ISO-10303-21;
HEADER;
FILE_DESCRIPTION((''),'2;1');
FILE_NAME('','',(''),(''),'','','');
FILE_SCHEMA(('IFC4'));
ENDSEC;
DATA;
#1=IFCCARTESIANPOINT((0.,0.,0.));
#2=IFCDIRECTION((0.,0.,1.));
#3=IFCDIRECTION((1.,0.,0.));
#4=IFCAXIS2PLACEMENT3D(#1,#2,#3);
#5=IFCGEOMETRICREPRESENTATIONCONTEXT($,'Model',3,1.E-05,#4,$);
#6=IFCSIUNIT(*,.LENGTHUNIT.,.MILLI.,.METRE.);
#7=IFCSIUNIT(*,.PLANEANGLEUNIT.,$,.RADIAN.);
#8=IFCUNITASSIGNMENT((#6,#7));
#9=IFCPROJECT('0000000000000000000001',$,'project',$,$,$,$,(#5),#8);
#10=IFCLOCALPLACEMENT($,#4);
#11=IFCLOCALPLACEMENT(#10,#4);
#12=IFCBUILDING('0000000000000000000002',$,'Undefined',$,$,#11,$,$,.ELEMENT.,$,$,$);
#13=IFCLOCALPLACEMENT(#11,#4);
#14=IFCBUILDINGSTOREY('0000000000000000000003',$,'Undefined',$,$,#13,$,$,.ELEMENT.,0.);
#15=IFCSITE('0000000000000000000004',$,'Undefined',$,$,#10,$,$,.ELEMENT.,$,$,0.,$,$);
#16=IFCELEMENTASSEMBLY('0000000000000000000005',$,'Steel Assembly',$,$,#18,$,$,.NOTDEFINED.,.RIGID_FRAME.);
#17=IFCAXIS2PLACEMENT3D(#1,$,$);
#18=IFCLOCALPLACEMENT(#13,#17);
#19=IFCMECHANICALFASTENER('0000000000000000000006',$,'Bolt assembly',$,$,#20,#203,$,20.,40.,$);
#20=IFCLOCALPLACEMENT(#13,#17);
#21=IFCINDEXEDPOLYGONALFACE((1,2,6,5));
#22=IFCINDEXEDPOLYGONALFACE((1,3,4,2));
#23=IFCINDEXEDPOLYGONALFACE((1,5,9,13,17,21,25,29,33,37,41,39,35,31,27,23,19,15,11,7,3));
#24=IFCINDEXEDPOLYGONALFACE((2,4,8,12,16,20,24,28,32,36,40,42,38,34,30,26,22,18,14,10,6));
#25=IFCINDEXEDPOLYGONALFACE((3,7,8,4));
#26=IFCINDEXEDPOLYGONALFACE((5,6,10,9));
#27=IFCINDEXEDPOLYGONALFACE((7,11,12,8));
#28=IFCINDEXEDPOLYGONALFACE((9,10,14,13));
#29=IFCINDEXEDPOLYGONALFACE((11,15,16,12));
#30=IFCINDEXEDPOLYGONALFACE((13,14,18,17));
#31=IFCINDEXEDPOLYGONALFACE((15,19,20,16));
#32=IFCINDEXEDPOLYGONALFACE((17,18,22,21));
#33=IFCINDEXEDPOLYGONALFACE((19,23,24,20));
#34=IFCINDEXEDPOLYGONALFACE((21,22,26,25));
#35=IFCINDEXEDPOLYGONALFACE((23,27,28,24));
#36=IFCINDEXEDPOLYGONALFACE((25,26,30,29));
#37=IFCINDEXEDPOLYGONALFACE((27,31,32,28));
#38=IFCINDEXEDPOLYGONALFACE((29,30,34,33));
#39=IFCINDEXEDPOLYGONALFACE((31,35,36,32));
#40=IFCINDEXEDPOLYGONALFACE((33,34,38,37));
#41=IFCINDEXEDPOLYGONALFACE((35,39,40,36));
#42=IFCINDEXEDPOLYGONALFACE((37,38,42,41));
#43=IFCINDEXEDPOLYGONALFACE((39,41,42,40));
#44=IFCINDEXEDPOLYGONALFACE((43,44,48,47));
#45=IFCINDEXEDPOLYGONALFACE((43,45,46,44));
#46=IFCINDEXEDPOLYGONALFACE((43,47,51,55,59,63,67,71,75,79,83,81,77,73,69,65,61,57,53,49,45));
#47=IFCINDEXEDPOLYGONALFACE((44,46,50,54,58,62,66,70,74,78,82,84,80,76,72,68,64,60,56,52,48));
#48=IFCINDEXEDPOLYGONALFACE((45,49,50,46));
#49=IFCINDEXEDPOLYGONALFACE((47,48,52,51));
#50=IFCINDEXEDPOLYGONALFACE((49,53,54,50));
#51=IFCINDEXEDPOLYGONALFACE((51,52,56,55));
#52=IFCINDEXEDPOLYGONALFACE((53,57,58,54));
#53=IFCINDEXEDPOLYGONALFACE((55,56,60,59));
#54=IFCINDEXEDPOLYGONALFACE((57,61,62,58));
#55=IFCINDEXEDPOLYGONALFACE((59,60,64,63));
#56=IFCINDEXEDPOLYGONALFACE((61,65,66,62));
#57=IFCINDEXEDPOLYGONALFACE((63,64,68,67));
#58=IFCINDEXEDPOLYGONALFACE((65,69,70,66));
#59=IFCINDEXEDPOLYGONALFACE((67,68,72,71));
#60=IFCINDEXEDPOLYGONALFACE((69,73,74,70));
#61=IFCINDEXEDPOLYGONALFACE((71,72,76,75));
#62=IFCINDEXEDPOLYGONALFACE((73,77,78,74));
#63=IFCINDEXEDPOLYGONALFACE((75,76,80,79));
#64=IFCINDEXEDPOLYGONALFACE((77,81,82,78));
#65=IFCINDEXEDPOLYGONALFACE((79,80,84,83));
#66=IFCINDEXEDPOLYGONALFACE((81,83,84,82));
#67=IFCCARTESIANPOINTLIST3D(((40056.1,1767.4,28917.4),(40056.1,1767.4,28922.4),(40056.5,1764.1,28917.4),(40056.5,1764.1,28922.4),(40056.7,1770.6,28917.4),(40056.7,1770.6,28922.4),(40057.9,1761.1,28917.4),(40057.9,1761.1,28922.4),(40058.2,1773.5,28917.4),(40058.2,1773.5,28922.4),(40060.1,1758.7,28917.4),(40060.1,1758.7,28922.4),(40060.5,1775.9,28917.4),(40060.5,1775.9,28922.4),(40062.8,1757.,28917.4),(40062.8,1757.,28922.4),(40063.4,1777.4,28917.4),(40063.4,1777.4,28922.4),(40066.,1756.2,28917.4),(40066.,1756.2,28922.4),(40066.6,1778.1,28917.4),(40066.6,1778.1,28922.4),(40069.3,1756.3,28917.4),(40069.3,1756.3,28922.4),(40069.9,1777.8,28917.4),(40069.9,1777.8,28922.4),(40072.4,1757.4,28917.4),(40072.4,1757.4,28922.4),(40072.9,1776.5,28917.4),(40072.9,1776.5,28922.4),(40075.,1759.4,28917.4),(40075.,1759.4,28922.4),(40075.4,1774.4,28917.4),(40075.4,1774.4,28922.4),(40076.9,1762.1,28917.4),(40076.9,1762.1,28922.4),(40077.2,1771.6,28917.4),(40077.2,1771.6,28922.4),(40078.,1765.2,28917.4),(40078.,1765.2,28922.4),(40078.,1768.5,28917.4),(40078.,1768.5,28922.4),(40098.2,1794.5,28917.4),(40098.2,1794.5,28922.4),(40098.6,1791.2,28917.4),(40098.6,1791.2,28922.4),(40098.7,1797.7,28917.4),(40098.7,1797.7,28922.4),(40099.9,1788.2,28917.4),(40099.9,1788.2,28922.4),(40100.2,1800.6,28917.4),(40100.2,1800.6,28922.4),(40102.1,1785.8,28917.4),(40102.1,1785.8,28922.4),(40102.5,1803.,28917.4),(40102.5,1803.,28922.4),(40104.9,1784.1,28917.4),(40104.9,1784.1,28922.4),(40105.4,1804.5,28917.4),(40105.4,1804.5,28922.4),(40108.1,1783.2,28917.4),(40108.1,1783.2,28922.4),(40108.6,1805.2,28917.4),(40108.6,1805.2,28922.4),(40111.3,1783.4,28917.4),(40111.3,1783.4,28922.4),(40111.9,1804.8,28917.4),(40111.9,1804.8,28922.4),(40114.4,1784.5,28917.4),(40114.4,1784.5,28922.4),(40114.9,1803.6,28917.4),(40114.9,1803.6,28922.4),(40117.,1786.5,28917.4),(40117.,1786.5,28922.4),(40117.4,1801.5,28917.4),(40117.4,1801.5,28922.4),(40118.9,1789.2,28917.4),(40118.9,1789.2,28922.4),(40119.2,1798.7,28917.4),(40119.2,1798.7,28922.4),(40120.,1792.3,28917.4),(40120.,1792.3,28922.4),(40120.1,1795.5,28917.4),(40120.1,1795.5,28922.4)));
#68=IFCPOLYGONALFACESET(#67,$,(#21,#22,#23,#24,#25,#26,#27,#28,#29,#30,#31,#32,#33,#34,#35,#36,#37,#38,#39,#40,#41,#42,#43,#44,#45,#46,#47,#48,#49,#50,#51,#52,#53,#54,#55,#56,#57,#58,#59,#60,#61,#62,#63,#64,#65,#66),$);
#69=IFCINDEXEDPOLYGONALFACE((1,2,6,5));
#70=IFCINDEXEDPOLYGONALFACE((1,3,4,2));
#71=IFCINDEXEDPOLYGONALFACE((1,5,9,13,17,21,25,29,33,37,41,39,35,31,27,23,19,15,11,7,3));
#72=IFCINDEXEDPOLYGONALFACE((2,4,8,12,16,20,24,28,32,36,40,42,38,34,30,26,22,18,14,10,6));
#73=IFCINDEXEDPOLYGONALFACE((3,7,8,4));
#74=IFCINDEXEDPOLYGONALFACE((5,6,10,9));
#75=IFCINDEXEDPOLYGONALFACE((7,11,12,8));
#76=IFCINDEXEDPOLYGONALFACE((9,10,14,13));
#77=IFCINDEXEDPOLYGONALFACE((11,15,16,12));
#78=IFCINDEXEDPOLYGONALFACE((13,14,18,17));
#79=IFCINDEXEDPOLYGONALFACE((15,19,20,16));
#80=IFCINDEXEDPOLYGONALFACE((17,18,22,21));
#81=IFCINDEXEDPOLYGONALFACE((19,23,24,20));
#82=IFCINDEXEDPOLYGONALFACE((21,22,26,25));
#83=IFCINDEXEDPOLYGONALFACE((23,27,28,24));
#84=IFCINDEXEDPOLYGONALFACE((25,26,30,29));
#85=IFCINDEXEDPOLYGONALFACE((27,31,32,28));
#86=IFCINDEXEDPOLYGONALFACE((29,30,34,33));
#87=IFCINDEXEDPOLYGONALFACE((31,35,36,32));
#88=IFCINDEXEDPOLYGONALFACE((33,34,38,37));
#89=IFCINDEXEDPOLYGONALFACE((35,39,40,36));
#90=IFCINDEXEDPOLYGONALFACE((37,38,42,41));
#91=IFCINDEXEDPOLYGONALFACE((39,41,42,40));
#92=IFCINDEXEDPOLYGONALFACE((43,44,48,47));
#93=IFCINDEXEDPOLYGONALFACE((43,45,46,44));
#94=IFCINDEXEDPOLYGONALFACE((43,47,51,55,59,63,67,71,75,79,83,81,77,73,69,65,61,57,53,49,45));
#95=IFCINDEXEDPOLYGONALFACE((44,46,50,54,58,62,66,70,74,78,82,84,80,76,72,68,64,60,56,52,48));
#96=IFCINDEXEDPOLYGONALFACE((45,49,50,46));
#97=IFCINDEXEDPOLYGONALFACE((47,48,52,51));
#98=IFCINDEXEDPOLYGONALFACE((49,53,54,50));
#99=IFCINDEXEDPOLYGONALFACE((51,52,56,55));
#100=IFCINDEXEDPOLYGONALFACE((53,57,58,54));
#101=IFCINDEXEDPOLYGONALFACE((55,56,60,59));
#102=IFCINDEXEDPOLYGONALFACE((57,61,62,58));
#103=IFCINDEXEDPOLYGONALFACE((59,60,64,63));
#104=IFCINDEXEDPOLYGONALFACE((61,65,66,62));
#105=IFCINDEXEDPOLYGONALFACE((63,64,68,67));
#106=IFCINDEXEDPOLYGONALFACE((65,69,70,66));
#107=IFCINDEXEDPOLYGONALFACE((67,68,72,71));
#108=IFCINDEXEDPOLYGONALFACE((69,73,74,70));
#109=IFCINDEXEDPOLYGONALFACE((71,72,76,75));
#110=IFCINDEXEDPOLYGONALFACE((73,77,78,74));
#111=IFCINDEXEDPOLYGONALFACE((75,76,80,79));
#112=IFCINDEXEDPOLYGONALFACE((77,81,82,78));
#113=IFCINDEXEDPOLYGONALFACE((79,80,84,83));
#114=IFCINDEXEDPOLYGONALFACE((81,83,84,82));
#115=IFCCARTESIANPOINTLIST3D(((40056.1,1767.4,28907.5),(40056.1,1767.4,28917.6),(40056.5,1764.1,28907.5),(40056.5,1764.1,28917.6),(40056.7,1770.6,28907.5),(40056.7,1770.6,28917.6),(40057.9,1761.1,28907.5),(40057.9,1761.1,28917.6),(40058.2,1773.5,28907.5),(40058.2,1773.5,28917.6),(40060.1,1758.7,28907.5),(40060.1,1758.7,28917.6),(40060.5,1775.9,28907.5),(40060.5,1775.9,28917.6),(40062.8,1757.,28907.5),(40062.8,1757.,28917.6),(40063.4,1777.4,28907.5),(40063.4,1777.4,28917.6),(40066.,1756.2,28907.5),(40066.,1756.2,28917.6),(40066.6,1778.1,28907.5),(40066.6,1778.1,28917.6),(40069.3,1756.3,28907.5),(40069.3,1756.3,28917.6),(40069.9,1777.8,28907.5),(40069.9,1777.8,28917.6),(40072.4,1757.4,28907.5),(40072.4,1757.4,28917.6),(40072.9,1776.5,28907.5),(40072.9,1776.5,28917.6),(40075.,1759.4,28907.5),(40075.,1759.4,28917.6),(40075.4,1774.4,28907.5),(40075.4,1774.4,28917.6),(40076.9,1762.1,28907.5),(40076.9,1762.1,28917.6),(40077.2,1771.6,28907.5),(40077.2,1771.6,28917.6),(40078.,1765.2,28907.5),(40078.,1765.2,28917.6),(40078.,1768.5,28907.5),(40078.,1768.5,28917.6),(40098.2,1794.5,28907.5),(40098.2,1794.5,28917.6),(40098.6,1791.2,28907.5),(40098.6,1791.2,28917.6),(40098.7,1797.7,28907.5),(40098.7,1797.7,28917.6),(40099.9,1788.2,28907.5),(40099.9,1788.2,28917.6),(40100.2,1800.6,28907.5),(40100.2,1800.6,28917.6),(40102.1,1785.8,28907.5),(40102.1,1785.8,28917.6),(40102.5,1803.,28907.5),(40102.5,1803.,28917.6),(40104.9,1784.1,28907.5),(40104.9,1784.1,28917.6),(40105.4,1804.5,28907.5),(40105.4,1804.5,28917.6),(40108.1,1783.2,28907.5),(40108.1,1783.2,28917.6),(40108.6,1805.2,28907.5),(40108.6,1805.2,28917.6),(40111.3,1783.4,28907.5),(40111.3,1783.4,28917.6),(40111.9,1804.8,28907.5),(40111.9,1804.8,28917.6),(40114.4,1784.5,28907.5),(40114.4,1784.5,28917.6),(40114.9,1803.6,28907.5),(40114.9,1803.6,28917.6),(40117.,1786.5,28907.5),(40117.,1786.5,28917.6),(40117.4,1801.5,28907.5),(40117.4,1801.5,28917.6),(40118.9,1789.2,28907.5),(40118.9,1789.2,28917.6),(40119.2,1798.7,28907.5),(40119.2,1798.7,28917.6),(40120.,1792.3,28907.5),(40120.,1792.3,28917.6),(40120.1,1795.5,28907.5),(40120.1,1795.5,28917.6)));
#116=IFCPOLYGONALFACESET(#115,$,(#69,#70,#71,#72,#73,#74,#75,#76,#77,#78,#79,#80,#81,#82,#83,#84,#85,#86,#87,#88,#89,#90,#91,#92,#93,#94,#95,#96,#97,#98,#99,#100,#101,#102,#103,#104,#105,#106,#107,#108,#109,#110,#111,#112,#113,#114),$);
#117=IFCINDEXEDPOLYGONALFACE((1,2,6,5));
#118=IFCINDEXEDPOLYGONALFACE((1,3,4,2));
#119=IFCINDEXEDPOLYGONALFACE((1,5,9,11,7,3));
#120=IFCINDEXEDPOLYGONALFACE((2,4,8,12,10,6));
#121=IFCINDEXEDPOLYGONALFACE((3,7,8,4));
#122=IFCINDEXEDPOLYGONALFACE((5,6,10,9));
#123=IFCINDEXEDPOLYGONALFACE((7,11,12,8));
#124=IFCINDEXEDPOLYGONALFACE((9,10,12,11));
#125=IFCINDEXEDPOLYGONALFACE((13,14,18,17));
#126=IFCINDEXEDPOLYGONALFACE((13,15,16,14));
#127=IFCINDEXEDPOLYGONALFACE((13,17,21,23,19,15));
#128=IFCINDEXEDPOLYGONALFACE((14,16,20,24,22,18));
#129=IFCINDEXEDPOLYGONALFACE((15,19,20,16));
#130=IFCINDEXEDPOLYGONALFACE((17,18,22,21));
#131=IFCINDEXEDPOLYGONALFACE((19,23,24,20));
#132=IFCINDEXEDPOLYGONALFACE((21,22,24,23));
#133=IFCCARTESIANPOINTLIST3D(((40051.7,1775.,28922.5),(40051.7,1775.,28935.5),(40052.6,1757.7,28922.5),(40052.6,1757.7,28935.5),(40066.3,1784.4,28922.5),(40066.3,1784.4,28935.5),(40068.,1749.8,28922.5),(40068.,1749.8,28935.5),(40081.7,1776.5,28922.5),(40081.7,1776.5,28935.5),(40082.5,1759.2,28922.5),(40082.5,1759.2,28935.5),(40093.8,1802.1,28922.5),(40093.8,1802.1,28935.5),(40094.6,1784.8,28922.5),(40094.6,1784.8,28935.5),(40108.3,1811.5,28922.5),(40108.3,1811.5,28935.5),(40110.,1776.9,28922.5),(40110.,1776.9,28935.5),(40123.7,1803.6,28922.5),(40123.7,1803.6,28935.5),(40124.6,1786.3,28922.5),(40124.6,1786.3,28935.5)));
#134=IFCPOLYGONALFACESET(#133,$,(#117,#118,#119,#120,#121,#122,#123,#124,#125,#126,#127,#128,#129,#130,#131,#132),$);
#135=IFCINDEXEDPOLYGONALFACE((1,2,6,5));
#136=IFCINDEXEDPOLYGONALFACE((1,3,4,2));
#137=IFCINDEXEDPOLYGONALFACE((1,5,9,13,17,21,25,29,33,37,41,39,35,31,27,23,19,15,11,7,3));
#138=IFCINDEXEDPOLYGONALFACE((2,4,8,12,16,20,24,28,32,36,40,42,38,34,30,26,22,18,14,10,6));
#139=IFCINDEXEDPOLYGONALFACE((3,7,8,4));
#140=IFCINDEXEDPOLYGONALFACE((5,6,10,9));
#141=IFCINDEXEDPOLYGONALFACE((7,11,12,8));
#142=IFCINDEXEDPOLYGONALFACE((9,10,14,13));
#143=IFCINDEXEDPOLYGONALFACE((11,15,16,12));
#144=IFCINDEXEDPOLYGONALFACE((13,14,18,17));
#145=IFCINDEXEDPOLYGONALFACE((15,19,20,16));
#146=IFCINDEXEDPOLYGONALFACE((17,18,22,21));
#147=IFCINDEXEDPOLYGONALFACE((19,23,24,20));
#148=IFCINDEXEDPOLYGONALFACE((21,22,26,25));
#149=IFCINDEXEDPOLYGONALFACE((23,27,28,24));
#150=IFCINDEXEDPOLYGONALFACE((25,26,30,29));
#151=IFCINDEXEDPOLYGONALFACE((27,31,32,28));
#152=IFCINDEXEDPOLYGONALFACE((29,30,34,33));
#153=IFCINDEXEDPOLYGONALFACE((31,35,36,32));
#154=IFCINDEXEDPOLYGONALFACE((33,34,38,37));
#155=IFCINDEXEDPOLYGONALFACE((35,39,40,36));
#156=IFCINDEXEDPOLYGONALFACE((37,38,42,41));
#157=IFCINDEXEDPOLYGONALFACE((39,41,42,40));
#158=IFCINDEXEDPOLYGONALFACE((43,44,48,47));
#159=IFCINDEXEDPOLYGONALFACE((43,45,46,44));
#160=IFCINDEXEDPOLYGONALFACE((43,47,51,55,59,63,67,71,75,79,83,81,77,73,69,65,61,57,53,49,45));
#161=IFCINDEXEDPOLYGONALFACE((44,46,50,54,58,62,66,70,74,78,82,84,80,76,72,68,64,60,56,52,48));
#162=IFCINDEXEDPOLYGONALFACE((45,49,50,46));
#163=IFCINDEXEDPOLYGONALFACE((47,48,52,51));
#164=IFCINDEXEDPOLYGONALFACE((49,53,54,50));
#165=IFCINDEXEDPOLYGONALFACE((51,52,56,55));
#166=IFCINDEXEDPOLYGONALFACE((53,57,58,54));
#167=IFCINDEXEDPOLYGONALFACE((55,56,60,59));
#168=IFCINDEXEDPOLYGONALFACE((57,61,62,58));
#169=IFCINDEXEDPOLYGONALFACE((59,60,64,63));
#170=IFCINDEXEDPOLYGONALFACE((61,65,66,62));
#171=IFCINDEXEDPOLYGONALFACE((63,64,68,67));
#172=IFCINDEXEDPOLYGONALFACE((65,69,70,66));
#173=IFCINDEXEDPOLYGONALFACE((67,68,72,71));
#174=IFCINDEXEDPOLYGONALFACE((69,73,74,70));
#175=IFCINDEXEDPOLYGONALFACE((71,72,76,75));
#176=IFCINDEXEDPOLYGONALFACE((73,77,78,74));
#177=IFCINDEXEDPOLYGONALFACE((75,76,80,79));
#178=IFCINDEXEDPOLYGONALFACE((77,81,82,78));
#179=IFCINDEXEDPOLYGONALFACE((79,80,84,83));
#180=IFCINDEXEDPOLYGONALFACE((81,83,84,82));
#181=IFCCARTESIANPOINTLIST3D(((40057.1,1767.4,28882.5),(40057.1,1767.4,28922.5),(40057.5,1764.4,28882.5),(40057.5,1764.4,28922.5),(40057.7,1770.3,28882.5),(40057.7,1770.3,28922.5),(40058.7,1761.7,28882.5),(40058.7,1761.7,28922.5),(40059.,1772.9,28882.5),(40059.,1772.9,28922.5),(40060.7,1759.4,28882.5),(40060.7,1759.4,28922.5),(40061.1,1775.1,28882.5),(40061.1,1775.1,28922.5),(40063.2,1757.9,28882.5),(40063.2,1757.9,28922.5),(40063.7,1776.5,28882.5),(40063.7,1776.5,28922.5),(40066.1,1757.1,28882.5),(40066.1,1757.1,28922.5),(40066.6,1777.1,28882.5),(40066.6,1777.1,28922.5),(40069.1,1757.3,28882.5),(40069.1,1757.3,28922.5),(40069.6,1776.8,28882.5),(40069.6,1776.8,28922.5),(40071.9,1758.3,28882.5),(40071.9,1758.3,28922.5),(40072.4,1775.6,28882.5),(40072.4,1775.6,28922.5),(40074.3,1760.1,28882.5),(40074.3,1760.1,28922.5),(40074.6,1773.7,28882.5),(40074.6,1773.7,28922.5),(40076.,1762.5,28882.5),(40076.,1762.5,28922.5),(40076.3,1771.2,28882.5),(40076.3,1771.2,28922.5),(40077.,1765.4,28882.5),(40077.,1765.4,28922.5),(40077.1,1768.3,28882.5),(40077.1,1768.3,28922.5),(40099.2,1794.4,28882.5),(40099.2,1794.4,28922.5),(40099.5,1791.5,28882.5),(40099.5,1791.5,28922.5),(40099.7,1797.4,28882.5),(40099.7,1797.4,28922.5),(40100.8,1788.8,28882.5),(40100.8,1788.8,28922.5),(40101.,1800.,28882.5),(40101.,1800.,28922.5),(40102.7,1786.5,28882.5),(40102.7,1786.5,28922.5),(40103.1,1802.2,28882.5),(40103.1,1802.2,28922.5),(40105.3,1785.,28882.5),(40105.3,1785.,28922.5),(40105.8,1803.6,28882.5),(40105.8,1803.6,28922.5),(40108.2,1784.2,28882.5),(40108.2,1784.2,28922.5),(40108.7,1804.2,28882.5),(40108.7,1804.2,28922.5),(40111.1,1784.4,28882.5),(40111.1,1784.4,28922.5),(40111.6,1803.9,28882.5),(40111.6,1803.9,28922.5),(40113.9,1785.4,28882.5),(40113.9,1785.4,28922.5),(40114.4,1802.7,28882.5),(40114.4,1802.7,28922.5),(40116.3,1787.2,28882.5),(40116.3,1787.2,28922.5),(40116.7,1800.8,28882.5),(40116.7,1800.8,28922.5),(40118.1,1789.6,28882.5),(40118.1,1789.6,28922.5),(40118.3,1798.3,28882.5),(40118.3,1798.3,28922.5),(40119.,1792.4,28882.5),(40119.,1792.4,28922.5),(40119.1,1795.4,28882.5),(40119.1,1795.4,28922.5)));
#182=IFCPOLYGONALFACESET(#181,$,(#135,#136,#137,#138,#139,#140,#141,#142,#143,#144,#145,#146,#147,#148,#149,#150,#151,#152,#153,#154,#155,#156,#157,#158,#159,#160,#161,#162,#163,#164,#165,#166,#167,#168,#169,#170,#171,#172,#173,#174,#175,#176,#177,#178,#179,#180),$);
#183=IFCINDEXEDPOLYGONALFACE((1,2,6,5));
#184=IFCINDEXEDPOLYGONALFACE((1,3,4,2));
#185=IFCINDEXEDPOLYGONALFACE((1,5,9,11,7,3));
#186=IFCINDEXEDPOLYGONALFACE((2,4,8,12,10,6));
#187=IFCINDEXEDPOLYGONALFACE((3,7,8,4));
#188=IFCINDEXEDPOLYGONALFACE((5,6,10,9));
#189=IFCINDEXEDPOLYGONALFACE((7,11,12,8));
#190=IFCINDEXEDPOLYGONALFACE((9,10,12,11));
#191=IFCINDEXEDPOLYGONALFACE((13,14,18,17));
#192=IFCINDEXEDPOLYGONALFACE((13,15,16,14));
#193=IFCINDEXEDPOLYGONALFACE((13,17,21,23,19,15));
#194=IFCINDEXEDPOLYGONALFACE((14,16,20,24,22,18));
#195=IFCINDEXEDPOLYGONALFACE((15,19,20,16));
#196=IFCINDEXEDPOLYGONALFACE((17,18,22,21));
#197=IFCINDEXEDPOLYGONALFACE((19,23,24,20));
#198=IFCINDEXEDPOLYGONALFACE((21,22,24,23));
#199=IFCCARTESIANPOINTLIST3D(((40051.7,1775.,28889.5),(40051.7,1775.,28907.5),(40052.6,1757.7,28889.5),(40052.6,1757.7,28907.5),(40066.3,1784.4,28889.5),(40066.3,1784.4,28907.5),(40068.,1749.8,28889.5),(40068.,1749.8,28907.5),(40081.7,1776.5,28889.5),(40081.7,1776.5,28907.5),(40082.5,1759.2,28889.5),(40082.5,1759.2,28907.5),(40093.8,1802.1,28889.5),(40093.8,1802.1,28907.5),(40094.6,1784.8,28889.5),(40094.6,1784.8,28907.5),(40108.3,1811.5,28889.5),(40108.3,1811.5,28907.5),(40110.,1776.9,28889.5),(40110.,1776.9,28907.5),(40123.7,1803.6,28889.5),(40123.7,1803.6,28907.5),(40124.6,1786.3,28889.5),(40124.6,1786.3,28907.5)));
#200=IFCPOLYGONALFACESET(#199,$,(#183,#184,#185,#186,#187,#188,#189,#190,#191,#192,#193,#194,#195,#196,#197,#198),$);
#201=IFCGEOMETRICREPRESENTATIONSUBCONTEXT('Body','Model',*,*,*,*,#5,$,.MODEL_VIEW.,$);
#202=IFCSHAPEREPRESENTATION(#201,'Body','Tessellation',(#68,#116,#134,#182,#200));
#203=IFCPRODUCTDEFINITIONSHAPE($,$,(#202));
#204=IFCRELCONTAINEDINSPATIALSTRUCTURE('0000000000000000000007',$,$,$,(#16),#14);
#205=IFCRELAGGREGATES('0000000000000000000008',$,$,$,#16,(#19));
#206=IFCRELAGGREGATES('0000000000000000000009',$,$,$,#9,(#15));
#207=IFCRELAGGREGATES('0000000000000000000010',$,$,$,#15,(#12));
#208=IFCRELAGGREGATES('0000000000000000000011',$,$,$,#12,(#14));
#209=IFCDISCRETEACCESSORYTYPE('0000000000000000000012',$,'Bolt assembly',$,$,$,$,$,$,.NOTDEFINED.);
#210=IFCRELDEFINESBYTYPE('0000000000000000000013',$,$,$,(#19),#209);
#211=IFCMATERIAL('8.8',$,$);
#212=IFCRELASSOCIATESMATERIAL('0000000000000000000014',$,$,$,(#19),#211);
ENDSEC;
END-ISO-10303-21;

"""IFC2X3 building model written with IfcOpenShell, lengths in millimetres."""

from ifc_helpers import new_model, si_unit, frame, origin_with_axes, origin_2d_with_axis, place, context, subcontext, project, spatial, polyline, circle, outline, extrude, source, transform, mapped, material, type_object, element, aggregate, save


model = new_model("IFC2X3")

# Units and contexts
model_context = context("Model", 3, precision=1e-05, world=origin_with_axes())
body_context = subcontext(model_context, "Body", "Model", "MODEL_VIEW")
ifc_project = project(units=[si_unit("LENGTHUNIT", "METRE", prefix="MILLI"), si_unit("PLANEANGLEUNIT", "RADIAN")], contexts=[model_context])

# Site, building, storey
site_placement = place(None, origin_with_axes())
site = spatial("IfcSite", under=ifc_project, at=site_placement, Name="Undefined", CompositionType="ELEMENT", RefElevation=0.0)
building_placement = place(site_placement, origin_with_axes())
building = spatial("IfcBuilding", under=site, at=building_placement, Name="Undefined", CompositionType="ELEMENT")
storey_placement = place(building_placement, origin_with_axes())
storey = spatial("IfcBuildingStorey", under=building, at=storey_placement, Name="Undefined", CompositionType="ELEMENT", Elevation=0.0)

# Shared definitions
discrete_accessory_type_1 = type_object("IfcDiscreteAccessoryType", Name="Bolt assembly")

# Shared definitions
ifc_material_1 = material(Name="8.8")

# Element assembly, mechanical fastener
shared_shape_1 = source(origin_with_axes(), body_context, "Body", "SweptSolid", [
    extrude(circle(Radius=11.0, at=origin_2d_with_axis()), frame((0.0, 0.1, 0.0), z_axis=(0.0, 1.0, 0.0), x_axis=(1.0, 0.0, 0.0)), (0.0, 0.0, 1.0), 5.0),
    extrude(circle(Radius=11.0, at=origin_2d_with_axis()), frame((0.0, 4.9, 0.0), z_axis=(0.0, 1.0, 0.0), x_axis=(1.0, 0.0, 0.0)), (0.0, 0.0, 1.0), 10.1),
    extrude(outline(polyline([(17.3, 0.0), (8.7, 15.0), (-8.7, 15.0), (-17.3, 0.0), (-8.7, -15.0), (8.7, -15.0), (17.3, 0.0)])), frame((0.0, -13.0, 0.0), z_axis=(0.0, 1.0, 0.0), x_axis=(1.0, 0.0, 0.0)), (0.0, 0.0, 1.0), 13.0),
    extrude(circle(Radius=10.0, at=origin_2d_with_axis()), frame((0.0, 0.0, 0.0), z_axis=(0.0, 1.0, 0.0), x_axis=(1.0, 0.0, 0.0)), (0.0, 0.0, 1.0), 40.0),
    extrude(outline(polyline([(17.3, 0.0), (8.7, 15.0), (-8.7, 15.0), (-17.3, 0.0), (-8.7, -15.0), (8.7, -15.0), (17.3, 0.0)])), frame((0.0, 15.0, 0.0), z_axis=(0.0, 1.0, 0.0), x_axis=(1.0, 0.0, 0.0)), (0.0, 0.0, 1.0), 18.0),
])
assembly_1_placement = place(storey_placement, origin_with_axes())
assembly_1 = element("IfcElementAssembly", 1, at=assembly_1_placement, inside=storey, Name="Steel Assembly", AssemblyPlace="NOTDEFINED", PredefinedType="RIGID_FRAME")
mechanical_fastener_1_placement = place(assembly_1_placement, frame((40109.2, 1794.2, 28922.5), z_axis=(0.541668, -0.840592, 0.0), x_axis=(-0.840592, -0.541668, 0.0)))
mechanical_fastener_1 = element("IfcMechanicalFastener", 2, at=mechanical_fastener_1_placement, type_object=discrete_accessory_type_1, material=ifc_material_1, Name="Bolt assembly", NominalDiameter=20.0, NominalLength=40.0, context=body_context, shape_type="MappedRepresentation", body=[
    mapped(shared_shape_1, transform((0.0, 0.0, 0.0))),
    mapped(shared_shape_1, transform((50.0, 0.0, 0.0))),
])
aggregate(assembly_1, [mechanical_fastener_1])

save(model, "model.ifc")
